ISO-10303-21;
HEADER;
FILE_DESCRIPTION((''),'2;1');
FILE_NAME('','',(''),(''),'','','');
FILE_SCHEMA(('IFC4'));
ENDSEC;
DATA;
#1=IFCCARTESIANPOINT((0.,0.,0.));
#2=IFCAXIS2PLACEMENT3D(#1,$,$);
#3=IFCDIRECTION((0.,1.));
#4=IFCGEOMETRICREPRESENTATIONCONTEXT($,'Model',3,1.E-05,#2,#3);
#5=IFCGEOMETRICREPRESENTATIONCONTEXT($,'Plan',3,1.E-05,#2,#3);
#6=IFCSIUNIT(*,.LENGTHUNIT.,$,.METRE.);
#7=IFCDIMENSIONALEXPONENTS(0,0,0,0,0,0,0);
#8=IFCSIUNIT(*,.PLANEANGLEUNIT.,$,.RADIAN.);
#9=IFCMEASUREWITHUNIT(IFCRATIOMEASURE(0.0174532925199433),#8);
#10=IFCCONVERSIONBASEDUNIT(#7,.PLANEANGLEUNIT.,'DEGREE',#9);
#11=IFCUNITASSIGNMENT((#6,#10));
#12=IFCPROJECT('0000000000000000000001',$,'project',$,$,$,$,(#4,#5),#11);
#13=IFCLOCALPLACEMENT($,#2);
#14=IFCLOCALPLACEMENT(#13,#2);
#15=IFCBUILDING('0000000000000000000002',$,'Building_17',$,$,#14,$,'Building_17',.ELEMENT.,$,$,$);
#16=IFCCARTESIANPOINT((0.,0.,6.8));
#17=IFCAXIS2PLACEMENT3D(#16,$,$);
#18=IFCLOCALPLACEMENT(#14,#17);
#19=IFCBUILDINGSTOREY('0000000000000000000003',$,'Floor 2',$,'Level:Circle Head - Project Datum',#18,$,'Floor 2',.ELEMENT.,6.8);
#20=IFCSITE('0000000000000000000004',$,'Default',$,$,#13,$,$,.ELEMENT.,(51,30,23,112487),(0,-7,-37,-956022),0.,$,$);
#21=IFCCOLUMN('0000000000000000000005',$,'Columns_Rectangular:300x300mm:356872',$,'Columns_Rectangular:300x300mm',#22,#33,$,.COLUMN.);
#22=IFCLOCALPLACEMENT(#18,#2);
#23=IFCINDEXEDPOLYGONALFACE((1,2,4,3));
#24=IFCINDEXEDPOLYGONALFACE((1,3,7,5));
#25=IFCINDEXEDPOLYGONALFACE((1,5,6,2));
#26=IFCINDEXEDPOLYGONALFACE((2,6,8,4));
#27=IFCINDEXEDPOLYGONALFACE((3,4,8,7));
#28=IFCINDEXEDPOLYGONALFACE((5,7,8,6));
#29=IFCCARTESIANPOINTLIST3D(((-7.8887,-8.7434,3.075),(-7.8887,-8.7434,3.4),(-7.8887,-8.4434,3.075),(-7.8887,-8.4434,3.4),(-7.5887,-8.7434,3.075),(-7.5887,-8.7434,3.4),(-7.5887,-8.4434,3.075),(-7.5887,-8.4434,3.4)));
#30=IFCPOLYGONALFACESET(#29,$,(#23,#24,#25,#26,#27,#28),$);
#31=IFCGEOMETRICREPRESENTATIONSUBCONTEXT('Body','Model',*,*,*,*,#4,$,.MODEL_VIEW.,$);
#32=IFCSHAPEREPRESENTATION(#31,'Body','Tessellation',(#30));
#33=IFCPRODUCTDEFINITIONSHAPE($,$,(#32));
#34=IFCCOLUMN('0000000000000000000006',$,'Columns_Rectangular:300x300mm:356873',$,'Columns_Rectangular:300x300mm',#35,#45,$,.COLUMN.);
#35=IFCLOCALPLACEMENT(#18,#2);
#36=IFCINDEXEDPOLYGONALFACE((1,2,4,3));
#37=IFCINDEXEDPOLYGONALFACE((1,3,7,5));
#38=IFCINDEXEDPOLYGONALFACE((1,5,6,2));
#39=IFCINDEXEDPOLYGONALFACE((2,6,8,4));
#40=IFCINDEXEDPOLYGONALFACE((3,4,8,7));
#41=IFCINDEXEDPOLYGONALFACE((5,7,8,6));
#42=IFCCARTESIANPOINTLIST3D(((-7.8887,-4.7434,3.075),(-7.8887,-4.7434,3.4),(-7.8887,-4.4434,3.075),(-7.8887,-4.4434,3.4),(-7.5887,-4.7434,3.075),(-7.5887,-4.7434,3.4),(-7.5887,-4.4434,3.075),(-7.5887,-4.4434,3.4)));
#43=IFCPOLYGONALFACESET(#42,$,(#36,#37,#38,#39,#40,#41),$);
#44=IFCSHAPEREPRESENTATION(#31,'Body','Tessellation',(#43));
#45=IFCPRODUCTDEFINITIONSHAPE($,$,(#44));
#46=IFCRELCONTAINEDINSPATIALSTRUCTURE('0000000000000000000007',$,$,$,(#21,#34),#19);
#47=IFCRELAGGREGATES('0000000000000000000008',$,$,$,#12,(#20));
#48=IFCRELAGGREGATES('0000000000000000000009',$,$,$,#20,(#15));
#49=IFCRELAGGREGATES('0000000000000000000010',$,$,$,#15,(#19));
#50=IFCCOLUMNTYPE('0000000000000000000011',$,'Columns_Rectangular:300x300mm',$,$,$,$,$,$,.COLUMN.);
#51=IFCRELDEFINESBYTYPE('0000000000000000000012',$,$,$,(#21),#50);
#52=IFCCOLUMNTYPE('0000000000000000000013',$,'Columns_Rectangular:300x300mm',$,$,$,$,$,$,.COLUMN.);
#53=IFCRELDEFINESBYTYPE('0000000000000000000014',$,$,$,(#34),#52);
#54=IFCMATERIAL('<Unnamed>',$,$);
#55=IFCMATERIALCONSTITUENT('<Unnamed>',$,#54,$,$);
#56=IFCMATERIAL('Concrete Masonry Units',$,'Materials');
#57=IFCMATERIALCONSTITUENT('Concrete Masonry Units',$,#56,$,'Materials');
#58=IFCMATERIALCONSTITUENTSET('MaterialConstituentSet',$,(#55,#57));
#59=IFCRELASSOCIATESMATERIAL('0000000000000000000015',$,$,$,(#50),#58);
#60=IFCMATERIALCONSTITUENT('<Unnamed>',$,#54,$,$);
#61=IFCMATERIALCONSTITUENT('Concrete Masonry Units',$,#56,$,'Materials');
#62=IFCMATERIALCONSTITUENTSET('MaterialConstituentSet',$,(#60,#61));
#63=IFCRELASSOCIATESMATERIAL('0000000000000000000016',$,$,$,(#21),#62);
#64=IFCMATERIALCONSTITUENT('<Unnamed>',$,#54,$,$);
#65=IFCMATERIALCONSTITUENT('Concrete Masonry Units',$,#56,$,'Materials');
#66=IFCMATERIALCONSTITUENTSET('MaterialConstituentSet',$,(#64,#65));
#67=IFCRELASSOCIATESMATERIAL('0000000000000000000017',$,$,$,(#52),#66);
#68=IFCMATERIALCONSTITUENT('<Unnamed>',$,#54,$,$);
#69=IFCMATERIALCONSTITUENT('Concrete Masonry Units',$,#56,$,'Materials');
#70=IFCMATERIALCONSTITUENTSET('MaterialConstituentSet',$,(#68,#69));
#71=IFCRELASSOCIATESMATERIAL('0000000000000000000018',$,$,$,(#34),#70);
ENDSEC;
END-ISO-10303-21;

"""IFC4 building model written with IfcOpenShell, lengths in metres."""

from ifc_helpers import new_model, entity, si_unit, converted_unit, direction, frame, origin, place, context, subcontext, project, spatial, indexed_curve, outline, extrude, source, transform, mapped, material, constituent, constituent_set, type_object, type_shapes, element, save


model = new_model("IFC4")

# Units and contexts
model_context = context("Model", 3, precision=1e-05, world=origin(), true_north=direction((0.0, 1.0)))
plan_context = context("Plan", 3, precision=1e-05, world=origin(), true_north=direction((0.0, 1.0)))
body_context = subcontext(model_context, "Body", "Model", "MODEL_VIEW")
ifc_project = project(units=[si_unit("LENGTHUNIT", "METRE"), converted_unit("PLANEANGLEUNIT", "DEGREE", entity("IfcRatioMeasure", 0.0174532925199433), si_unit("PLANEANGLEUNIT", "RADIAN"), dimensions=[0, 0, 0, 0, 0, 0, 0])], contexts=[model_context, plan_context])

# Site, building, storey
site_placement = place(None, origin())
site = spatial("IfcSite", under=ifc_project, at=site_placement, Name="Default", CompositionType="ELEMENT", RefLatitude=(51, 30, 23, 112487), RefLongitude=(0, -7, -37, -956022), RefElevation=0.0)
building_placement = place(site_placement, origin())
building = spatial("IfcBuilding", under=site, at=building_placement, Name="Building_17", LongName="Building_17", CompositionType="ELEMENT")
storey_placement = place(building_placement, frame((0.0, 0.0, 6.8)))
storey = spatial("IfcBuildingStorey", under=building, at=storey_placement, Name="Floor 2", ObjectType="Level:Circle Head - Project Datum", LongName="Floor 2", CompositionType="ELEMENT", Elevation=6.8)

# Columns
ifc_material_1 = material(Name="<Unnamed>")
ifc_material_2 = material(Name="Concrete Masonry Units", Category="Materials")
ifc_constituent_1 = constituent(ifc_material_1, Name="<Unnamed>")
ifc_constituent_2 = constituent(ifc_material_2, Name="Concrete Masonry Units", Category="Materials")
ifc_constituent_set_1 = constituent_set(constituents=[ifc_constituent_1, ifc_constituent_2], Name="MaterialConstituentSet")
ifc_constituent_3 = constituent(ifc_material_1, Name="<Unnamed>")
ifc_constituent_4 = constituent(ifc_material_2, Name="Concrete Masonry Units", Category="Materials")
ifc_constituent_set_2 = constituent_set(constituents=[ifc_constituent_3, ifc_constituent_4], Name="MaterialConstituentSet")
column_type_1 = type_object("IfcColumnType", Name="Columns_Rectangular:300x300mm", PredefinedType="COLUMN", material=ifc_constituent_set_2)
shared_shape_1 = source(origin(), body_context, "Body", "SweptSolid", [
    extrude(outline(indexed_curve([(-0.15, -0.15), (0.15, -0.15), (0.15, 0.15), (-0.15, 0.15), (-0.15, -0.15)], self_intersect=False)), frame((-7.7387, -8.5934, 9.875), z_axis=(0.0, 0.0, 1.0), x_axis=(0.0, -1.0, 0.0)), (0.0, 0.0, 1.0), 0.325),
])
type_shapes(column_type_1, [shared_shape_1])
column_1_placement = place(storey_placement, frame((0.0, 0.0, -6.8)))
element("IfcColumn", 1, at=column_1_placement, inside=storey, type_object=column_type_1, material=ifc_constituent_set_1, Name="Columns_Rectangular:300x300mm:356872", ObjectType="Columns_Rectangular:300x300mm", PredefinedType="COLUMN", context=body_context, shape_type="MappedRepresentation", body=[
    mapped(shared_shape_1, transform((0.0, 0.0, 0.0), scale=1.0)),
])
ifc_constituent_5 = constituent(ifc_material_1, Name="<Unnamed>")
ifc_constituent_6 = constituent(ifc_material_2, Name="Concrete Masonry Units", Category="Materials")
ifc_constituent_set_3 = constituent_set(constituents=[ifc_constituent_5, ifc_constituent_6], Name="MaterialConstituentSet")
ifc_constituent_7 = constituent(ifc_material_1, Name="<Unnamed>")
ifc_constituent_8 = constituent(ifc_material_2, Name="Concrete Masonry Units", Category="Materials")
ifc_constituent_set_4 = constituent_set(constituents=[ifc_constituent_7, ifc_constituent_8], Name="MaterialConstituentSet")
column_type_2 = type_object("IfcColumnType", Name="Columns_Rectangular:300x300mm", PredefinedType="COLUMN", material=ifc_constituent_set_4)
shared_shape_2 = source(origin(), body_context, "Body", "SweptSolid", [
    extrude(outline(indexed_curve([(-0.15, -0.15), (0.15, -0.15), (0.15, 0.15), (-0.15, 0.15), (-0.15, -0.15)], self_intersect=False)), frame((-7.7387, -4.5934, 9.875), z_axis=(0.0, 0.0, 1.0), x_axis=(0.0, -1.0, 0.0)), (0.0, 0.0, 1.0), 0.325),
])
type_shapes(column_type_2, [shared_shape_2])
column_2_placement = place(storey_placement, frame((0.0, 0.0, -6.8)))
element("IfcColumn", 2, at=column_2_placement, inside=storey, type_object=column_type_2, material=ifc_constituent_set_3, Name="Columns_Rectangular:300x300mm:356873", ObjectType="Columns_Rectangular:300x300mm", PredefinedType="COLUMN", context=body_context, shape_type="MappedRepresentation", body=[
    mapped(shared_shape_2, transform((0.0, 0.0, 0.0), scale=1.0)),
])

save(model, "model.ifc")
